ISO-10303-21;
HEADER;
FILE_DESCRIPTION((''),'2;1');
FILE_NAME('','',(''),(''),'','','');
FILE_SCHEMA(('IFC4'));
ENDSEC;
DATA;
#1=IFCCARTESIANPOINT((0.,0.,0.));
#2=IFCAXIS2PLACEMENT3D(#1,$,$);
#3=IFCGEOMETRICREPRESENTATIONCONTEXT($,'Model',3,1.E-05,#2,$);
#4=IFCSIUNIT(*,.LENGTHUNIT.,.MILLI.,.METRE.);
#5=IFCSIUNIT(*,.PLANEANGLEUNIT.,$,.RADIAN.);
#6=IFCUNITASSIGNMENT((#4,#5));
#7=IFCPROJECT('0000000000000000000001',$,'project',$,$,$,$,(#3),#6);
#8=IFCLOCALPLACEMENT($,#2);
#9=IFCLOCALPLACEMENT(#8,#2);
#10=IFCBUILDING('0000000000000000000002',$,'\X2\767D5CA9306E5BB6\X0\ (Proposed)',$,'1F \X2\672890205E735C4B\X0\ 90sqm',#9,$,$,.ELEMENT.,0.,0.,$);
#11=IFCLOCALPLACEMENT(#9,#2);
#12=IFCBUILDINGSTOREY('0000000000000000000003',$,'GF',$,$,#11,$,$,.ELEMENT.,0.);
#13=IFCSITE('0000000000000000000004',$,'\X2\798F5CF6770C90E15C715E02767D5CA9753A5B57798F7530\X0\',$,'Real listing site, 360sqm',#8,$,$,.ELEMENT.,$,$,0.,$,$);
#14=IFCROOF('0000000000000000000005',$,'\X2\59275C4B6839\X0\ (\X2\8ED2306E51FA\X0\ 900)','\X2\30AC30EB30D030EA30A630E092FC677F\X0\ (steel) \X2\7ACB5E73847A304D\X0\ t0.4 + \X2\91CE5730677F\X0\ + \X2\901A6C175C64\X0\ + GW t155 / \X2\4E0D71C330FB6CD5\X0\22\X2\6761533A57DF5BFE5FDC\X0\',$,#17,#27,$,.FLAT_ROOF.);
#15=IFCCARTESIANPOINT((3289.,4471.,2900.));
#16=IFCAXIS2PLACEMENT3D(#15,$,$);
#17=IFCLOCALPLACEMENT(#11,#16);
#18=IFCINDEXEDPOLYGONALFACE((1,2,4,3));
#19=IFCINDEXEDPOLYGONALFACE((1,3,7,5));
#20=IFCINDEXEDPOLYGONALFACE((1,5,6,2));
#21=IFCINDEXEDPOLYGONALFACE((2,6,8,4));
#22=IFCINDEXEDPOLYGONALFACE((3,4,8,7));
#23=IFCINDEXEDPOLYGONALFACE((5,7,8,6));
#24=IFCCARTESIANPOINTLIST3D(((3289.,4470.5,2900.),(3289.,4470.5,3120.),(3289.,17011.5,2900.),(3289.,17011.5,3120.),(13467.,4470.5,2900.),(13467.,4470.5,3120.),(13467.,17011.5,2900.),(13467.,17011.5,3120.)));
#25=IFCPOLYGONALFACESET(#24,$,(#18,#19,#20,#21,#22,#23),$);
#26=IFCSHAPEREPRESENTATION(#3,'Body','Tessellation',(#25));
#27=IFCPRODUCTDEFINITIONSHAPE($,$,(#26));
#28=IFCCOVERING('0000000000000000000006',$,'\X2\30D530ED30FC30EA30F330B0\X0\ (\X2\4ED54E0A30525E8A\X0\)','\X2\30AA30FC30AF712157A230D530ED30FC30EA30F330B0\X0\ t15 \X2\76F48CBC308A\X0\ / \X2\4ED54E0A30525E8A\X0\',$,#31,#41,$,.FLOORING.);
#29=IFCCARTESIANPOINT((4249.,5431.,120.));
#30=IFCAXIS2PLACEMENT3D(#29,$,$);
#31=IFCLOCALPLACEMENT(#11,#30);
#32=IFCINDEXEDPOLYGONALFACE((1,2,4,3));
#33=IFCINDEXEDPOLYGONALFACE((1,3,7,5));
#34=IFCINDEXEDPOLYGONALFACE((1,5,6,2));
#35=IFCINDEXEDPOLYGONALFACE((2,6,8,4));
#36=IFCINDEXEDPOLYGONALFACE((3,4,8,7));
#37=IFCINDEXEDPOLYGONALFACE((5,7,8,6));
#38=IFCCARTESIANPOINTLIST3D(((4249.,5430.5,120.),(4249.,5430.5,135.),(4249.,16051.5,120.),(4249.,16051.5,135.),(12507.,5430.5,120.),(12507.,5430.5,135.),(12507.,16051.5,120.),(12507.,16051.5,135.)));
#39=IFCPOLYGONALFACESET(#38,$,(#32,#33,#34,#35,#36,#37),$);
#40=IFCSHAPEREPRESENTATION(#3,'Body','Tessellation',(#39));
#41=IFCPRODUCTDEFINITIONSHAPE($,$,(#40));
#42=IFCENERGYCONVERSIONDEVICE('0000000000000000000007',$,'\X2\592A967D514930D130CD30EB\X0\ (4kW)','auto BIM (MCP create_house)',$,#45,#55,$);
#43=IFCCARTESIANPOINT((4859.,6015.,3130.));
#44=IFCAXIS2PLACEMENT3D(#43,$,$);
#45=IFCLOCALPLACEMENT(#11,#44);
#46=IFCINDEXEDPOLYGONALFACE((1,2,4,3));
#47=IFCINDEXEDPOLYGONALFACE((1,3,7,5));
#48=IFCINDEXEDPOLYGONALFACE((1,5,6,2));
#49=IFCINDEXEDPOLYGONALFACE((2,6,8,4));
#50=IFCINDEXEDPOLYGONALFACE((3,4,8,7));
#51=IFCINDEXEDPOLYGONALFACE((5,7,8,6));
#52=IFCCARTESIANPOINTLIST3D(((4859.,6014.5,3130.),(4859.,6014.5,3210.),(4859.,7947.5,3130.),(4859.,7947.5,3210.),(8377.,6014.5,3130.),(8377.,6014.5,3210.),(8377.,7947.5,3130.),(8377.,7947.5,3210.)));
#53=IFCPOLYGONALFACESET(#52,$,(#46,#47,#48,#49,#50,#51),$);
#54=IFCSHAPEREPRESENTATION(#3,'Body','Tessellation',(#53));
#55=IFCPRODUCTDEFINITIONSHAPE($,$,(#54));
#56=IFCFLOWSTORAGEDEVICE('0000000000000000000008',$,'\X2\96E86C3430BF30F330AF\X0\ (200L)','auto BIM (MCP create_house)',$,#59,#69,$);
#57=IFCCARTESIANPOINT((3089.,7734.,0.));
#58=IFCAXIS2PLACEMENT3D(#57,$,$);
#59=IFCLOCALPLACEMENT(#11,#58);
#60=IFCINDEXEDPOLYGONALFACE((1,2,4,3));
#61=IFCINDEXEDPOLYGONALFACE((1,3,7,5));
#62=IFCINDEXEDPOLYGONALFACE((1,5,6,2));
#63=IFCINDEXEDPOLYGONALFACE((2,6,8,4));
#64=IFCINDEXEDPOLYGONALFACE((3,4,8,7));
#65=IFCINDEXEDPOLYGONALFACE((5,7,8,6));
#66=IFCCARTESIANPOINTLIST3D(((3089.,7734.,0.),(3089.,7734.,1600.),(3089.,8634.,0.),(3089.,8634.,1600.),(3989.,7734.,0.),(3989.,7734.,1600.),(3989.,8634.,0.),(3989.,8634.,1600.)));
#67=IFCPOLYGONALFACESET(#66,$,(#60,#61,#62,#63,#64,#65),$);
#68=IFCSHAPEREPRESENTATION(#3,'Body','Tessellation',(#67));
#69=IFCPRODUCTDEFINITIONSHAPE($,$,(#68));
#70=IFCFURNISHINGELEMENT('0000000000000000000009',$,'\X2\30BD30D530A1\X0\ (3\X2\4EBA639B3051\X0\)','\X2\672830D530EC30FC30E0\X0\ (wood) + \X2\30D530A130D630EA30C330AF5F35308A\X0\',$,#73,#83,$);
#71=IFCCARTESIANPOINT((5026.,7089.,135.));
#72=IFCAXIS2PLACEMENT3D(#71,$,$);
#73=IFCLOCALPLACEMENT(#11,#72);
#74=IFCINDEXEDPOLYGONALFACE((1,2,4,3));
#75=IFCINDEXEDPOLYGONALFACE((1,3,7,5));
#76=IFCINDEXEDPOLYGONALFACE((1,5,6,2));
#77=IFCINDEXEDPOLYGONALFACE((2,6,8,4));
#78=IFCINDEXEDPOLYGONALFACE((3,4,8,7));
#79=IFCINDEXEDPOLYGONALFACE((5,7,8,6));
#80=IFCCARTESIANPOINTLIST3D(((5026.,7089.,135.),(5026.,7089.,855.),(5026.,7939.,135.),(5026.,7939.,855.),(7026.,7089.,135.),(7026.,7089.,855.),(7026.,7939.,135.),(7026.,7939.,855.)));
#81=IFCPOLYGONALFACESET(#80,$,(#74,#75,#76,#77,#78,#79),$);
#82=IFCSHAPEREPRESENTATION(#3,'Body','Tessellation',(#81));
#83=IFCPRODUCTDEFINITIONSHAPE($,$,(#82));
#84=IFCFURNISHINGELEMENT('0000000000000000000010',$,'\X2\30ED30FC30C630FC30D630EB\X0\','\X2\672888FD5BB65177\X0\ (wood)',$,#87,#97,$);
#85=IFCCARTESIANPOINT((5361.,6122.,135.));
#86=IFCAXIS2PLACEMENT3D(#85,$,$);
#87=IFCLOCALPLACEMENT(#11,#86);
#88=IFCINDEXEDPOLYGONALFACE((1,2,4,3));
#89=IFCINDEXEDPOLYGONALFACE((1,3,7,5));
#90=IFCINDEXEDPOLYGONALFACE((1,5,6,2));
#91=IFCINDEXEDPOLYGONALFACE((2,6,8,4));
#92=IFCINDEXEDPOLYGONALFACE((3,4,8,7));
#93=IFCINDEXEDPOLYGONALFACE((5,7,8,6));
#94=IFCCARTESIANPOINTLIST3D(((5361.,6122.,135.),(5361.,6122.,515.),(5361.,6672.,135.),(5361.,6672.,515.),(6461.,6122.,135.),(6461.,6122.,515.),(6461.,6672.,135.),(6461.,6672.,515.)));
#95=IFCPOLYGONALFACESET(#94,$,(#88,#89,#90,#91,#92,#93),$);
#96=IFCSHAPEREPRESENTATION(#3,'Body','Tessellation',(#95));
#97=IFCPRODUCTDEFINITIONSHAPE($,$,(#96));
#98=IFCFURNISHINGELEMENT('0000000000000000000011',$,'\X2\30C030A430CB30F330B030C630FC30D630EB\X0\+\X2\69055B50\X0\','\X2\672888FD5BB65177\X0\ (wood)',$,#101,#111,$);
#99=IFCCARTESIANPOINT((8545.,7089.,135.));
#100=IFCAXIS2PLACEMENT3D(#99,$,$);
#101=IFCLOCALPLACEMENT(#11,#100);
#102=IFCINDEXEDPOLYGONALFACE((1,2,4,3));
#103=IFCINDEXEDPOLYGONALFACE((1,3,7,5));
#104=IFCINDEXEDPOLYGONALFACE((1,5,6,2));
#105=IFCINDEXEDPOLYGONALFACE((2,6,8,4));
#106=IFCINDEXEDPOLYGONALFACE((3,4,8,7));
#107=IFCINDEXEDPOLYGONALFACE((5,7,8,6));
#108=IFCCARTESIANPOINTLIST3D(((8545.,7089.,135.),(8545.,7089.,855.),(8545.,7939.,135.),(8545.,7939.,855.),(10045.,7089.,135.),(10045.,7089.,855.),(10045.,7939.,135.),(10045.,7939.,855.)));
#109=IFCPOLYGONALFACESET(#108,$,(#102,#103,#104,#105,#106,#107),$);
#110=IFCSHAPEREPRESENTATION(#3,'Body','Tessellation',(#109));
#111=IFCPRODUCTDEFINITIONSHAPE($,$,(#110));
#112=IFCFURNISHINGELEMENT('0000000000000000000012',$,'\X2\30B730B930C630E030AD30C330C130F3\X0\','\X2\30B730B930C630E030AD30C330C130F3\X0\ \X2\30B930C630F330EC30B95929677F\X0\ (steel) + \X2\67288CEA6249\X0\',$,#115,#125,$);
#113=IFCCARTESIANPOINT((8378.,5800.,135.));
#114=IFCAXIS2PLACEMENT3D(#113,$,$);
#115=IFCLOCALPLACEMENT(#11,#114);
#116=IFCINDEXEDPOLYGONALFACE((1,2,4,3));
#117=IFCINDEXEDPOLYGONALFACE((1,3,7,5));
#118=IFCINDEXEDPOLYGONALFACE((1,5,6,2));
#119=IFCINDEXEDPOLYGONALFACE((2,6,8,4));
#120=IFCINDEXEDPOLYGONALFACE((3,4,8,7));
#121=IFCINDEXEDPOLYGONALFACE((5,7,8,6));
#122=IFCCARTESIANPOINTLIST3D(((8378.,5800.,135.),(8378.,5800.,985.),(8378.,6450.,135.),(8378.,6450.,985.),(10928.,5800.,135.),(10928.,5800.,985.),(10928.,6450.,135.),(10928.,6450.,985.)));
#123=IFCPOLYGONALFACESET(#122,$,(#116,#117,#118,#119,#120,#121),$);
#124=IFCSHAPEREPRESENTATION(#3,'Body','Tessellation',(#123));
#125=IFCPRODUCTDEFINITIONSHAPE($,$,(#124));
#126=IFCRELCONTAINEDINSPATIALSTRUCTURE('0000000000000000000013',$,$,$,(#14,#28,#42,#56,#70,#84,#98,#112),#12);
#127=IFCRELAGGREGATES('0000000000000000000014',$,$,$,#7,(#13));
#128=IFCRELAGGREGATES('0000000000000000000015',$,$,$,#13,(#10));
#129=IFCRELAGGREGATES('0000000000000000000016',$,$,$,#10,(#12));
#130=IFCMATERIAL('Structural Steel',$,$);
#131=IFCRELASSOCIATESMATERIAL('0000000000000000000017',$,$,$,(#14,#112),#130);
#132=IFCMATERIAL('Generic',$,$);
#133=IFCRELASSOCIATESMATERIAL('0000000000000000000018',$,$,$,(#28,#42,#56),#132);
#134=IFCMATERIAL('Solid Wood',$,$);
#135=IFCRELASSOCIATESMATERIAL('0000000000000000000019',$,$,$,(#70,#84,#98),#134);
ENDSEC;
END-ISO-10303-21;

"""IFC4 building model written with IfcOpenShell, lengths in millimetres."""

from ifc_helpers import new_model, si_unit, frame, frame_2d, origin, place, context, project, spatial, rectangle, extrude, material, element, save


model = new_model("IFC4")

# Units and contexts
model_context = context("Model", 3, precision=1e-05, world=origin())
ifc_project = project(units=[si_unit("LENGTHUNIT", "METRE", prefix="MILLI"), si_unit("PLANEANGLEUNIT", "RADIAN")], contexts=[model_context])

# Site, building, storey
site_placement = place(None, origin())
site = spatial("IfcSite", under=ifc_project, at=site_placement, Name="福島県郡山市白岩町字福田", ObjectType="Real listing site, 360sqm", CompositionType="ELEMENT", RefElevation=0.0)
building_placement = place(site_placement, origin())
building = spatial("IfcBuilding", under=site, at=building_placement, Name="白岩の家 (Proposed)", ObjectType="1F 木造平屋 90sqm", CompositionType="ELEMENT", ElevationOfRefHeight=0.0, ElevationOfTerrain=0.0)
storey_placement = place(building_placement, origin())
storey = spatial("IfcBuildingStorey", under=building, at=storey_placement, Name="GF", CompositionType="ELEMENT", Elevation=0.0)

# Shared definitions
ifc_material_1 = material(Name="Solid Wood")

# Roof
ifc_material_2 = material(Name="Structural Steel")
roof_placement = place(storey_placement, frame((3289.0, 4471.0, 2900.0)))
element("IfcRoof", 1, at=roof_placement, inside=storey, material=ifc_material_2, Name="大屋根 (軒の出 900)", Description="ガルバリウム鋼板 (steel) 立平葺き t0.4 + 野地板 + 通気層 + GW t155 / 不燃・法22条区域対応", PredefinedType="FLAT_ROOF", context=model_context, shape_type="SweptSolid", body=[
    extrude(rectangle(XDim=10178.0, YDim=12541.0, at=frame_2d((5089.0, 6270.0))), frame((3289.0, 4471.0, 2900.0)), (0.0, 0.0, 1.0), 220.0),
])

# Covering
ifc_material_3 = material(Name="Generic")
covering_placement = place(storey_placement, frame((4249.0, 5431.0, 120.0)))
element("IfcCovering", 2, at=covering_placement, inside=storey, material=ifc_material_3, Name="フローリング (仕上げ床)", Description="オーク無垢フローリング t15 直貼り / 仕上げ床", PredefinedType="FLOORING", context=model_context, shape_type="SweptSolid", body=[
    extrude(rectangle(XDim=8258.0, YDim=10621.0, at=frame_2d((4129.0, 5310.0))), frame((4249.0, 5431.0, 120.0)), (0.0, 0.0, 1.0), 15.0),
])

# Energy conversion device
energy_conversion_device_placement = place(storey_placement, frame((4859.0, 6015.0, 3130.0)))
element("IfcEnergyConversionDevice", 3, at=energy_conversion_device_placement, inside=storey, material=ifc_material_3, Name="太陽光パネル (4kW)", Description="auto BIM (MCP create_house)", context=model_context, shape_type="SweptSolid", body=[
    extrude(rectangle(XDim=3518.0, YDim=1933.0, at=frame_2d((1759.0, 966.0))), frame((4859.0, 6015.0, 3130.0)), (0.0, 0.0, 1.0), 80.0),
])

# Flow storage device
flow_storage_device_placement = place(storey_placement, frame((3089.0, 7734.0, 0.0)))
element("IfcFlowStorageDevice", 4, at=flow_storage_device_placement, inside=storey, material=ifc_material_3, Name="雨水タンク (200L)", Description="auto BIM (MCP create_house)", context=model_context, shape_type="SweptSolid", body=[
    extrude(rectangle(XDim=900.0, YDim=900.0, at=frame_2d((450.0, 450.0))), frame((3089.0, 7734.0, 0.0)), (0.0, 0.0, 1.0), 1600.0),
])

# Furnishing elements
furnishing_1_placement = place(storey_placement, frame((5026.0, 7089.0, 135.0)))
element("IfcFurnishingElement", 5, at=furnishing_1_placement, inside=storey, material=ifc_material_1, Name="ソファ (3人掛け)", Description="木フレーム (wood) + ファブリック張り", context=model_context, shape_type="SweptSolid", body=[
    extrude(rectangle(XDim=2000.0, YDim=850.0, at=frame_2d((1000.0, 425.0))), frame((5026.0, 7089.0, 135.0)), (0.0, 0.0, 1.0), 720.0),
])
furnishing_2_placement = place(storey_placement, frame((5361.0, 6122.0, 135.0)))
element("IfcFurnishingElement", 6, at=furnishing_2_placement, inside=storey, material=ifc_material_1, Name="ローテーブル", Description="木製家具 (wood)", context=model_context, shape_type="SweptSolid", body=[
    extrude(rectangle(XDim=1100.0, YDim=550.0, at=frame_2d((550.0, 275.0))), frame((5361.0, 6122.0, 135.0)), (0.0, 0.0, 1.0), 380.0),
])
furnishing_3_placement = place(storey_placement, frame((8545.0, 7089.0, 135.0)))
element("IfcFurnishingElement", 7, at=furnishing_3_placement, inside=storey, material=ifc_material_1, Name="ダイニングテーブル+椅子", Description="木製家具 (wood)", context=model_context, shape_type="SweptSolid", body=[
    extrude(rectangle(XDim=1500.0, YDim=850.0, at=frame_2d((750.0, 425.0))), frame((8545.0, 7089.0, 135.0)), (0.0, 0.0, 1.0), 720.0),
])
furnishing_4_placement = place(storey_placement, frame((8378.0, 5800.0, 135.0)))
element("IfcFurnishingElement", 8, at=furnishing_4_placement, inside=storey, material=ifc_material_2, Name="システムキッチン", Description="システムキッチン ステンレス天板 (steel) + 木質扉", context=model_context, shape_type="SweptSolid", body=[
    extrude(rectangle(XDim=2550.0, YDim=650.0, at=frame_2d((1275.0, 325.0))), frame((8378.0, 5800.0, 135.0)), (0.0, 0.0, 1.0), 850.0),
])

save(model, "model.ifc")
